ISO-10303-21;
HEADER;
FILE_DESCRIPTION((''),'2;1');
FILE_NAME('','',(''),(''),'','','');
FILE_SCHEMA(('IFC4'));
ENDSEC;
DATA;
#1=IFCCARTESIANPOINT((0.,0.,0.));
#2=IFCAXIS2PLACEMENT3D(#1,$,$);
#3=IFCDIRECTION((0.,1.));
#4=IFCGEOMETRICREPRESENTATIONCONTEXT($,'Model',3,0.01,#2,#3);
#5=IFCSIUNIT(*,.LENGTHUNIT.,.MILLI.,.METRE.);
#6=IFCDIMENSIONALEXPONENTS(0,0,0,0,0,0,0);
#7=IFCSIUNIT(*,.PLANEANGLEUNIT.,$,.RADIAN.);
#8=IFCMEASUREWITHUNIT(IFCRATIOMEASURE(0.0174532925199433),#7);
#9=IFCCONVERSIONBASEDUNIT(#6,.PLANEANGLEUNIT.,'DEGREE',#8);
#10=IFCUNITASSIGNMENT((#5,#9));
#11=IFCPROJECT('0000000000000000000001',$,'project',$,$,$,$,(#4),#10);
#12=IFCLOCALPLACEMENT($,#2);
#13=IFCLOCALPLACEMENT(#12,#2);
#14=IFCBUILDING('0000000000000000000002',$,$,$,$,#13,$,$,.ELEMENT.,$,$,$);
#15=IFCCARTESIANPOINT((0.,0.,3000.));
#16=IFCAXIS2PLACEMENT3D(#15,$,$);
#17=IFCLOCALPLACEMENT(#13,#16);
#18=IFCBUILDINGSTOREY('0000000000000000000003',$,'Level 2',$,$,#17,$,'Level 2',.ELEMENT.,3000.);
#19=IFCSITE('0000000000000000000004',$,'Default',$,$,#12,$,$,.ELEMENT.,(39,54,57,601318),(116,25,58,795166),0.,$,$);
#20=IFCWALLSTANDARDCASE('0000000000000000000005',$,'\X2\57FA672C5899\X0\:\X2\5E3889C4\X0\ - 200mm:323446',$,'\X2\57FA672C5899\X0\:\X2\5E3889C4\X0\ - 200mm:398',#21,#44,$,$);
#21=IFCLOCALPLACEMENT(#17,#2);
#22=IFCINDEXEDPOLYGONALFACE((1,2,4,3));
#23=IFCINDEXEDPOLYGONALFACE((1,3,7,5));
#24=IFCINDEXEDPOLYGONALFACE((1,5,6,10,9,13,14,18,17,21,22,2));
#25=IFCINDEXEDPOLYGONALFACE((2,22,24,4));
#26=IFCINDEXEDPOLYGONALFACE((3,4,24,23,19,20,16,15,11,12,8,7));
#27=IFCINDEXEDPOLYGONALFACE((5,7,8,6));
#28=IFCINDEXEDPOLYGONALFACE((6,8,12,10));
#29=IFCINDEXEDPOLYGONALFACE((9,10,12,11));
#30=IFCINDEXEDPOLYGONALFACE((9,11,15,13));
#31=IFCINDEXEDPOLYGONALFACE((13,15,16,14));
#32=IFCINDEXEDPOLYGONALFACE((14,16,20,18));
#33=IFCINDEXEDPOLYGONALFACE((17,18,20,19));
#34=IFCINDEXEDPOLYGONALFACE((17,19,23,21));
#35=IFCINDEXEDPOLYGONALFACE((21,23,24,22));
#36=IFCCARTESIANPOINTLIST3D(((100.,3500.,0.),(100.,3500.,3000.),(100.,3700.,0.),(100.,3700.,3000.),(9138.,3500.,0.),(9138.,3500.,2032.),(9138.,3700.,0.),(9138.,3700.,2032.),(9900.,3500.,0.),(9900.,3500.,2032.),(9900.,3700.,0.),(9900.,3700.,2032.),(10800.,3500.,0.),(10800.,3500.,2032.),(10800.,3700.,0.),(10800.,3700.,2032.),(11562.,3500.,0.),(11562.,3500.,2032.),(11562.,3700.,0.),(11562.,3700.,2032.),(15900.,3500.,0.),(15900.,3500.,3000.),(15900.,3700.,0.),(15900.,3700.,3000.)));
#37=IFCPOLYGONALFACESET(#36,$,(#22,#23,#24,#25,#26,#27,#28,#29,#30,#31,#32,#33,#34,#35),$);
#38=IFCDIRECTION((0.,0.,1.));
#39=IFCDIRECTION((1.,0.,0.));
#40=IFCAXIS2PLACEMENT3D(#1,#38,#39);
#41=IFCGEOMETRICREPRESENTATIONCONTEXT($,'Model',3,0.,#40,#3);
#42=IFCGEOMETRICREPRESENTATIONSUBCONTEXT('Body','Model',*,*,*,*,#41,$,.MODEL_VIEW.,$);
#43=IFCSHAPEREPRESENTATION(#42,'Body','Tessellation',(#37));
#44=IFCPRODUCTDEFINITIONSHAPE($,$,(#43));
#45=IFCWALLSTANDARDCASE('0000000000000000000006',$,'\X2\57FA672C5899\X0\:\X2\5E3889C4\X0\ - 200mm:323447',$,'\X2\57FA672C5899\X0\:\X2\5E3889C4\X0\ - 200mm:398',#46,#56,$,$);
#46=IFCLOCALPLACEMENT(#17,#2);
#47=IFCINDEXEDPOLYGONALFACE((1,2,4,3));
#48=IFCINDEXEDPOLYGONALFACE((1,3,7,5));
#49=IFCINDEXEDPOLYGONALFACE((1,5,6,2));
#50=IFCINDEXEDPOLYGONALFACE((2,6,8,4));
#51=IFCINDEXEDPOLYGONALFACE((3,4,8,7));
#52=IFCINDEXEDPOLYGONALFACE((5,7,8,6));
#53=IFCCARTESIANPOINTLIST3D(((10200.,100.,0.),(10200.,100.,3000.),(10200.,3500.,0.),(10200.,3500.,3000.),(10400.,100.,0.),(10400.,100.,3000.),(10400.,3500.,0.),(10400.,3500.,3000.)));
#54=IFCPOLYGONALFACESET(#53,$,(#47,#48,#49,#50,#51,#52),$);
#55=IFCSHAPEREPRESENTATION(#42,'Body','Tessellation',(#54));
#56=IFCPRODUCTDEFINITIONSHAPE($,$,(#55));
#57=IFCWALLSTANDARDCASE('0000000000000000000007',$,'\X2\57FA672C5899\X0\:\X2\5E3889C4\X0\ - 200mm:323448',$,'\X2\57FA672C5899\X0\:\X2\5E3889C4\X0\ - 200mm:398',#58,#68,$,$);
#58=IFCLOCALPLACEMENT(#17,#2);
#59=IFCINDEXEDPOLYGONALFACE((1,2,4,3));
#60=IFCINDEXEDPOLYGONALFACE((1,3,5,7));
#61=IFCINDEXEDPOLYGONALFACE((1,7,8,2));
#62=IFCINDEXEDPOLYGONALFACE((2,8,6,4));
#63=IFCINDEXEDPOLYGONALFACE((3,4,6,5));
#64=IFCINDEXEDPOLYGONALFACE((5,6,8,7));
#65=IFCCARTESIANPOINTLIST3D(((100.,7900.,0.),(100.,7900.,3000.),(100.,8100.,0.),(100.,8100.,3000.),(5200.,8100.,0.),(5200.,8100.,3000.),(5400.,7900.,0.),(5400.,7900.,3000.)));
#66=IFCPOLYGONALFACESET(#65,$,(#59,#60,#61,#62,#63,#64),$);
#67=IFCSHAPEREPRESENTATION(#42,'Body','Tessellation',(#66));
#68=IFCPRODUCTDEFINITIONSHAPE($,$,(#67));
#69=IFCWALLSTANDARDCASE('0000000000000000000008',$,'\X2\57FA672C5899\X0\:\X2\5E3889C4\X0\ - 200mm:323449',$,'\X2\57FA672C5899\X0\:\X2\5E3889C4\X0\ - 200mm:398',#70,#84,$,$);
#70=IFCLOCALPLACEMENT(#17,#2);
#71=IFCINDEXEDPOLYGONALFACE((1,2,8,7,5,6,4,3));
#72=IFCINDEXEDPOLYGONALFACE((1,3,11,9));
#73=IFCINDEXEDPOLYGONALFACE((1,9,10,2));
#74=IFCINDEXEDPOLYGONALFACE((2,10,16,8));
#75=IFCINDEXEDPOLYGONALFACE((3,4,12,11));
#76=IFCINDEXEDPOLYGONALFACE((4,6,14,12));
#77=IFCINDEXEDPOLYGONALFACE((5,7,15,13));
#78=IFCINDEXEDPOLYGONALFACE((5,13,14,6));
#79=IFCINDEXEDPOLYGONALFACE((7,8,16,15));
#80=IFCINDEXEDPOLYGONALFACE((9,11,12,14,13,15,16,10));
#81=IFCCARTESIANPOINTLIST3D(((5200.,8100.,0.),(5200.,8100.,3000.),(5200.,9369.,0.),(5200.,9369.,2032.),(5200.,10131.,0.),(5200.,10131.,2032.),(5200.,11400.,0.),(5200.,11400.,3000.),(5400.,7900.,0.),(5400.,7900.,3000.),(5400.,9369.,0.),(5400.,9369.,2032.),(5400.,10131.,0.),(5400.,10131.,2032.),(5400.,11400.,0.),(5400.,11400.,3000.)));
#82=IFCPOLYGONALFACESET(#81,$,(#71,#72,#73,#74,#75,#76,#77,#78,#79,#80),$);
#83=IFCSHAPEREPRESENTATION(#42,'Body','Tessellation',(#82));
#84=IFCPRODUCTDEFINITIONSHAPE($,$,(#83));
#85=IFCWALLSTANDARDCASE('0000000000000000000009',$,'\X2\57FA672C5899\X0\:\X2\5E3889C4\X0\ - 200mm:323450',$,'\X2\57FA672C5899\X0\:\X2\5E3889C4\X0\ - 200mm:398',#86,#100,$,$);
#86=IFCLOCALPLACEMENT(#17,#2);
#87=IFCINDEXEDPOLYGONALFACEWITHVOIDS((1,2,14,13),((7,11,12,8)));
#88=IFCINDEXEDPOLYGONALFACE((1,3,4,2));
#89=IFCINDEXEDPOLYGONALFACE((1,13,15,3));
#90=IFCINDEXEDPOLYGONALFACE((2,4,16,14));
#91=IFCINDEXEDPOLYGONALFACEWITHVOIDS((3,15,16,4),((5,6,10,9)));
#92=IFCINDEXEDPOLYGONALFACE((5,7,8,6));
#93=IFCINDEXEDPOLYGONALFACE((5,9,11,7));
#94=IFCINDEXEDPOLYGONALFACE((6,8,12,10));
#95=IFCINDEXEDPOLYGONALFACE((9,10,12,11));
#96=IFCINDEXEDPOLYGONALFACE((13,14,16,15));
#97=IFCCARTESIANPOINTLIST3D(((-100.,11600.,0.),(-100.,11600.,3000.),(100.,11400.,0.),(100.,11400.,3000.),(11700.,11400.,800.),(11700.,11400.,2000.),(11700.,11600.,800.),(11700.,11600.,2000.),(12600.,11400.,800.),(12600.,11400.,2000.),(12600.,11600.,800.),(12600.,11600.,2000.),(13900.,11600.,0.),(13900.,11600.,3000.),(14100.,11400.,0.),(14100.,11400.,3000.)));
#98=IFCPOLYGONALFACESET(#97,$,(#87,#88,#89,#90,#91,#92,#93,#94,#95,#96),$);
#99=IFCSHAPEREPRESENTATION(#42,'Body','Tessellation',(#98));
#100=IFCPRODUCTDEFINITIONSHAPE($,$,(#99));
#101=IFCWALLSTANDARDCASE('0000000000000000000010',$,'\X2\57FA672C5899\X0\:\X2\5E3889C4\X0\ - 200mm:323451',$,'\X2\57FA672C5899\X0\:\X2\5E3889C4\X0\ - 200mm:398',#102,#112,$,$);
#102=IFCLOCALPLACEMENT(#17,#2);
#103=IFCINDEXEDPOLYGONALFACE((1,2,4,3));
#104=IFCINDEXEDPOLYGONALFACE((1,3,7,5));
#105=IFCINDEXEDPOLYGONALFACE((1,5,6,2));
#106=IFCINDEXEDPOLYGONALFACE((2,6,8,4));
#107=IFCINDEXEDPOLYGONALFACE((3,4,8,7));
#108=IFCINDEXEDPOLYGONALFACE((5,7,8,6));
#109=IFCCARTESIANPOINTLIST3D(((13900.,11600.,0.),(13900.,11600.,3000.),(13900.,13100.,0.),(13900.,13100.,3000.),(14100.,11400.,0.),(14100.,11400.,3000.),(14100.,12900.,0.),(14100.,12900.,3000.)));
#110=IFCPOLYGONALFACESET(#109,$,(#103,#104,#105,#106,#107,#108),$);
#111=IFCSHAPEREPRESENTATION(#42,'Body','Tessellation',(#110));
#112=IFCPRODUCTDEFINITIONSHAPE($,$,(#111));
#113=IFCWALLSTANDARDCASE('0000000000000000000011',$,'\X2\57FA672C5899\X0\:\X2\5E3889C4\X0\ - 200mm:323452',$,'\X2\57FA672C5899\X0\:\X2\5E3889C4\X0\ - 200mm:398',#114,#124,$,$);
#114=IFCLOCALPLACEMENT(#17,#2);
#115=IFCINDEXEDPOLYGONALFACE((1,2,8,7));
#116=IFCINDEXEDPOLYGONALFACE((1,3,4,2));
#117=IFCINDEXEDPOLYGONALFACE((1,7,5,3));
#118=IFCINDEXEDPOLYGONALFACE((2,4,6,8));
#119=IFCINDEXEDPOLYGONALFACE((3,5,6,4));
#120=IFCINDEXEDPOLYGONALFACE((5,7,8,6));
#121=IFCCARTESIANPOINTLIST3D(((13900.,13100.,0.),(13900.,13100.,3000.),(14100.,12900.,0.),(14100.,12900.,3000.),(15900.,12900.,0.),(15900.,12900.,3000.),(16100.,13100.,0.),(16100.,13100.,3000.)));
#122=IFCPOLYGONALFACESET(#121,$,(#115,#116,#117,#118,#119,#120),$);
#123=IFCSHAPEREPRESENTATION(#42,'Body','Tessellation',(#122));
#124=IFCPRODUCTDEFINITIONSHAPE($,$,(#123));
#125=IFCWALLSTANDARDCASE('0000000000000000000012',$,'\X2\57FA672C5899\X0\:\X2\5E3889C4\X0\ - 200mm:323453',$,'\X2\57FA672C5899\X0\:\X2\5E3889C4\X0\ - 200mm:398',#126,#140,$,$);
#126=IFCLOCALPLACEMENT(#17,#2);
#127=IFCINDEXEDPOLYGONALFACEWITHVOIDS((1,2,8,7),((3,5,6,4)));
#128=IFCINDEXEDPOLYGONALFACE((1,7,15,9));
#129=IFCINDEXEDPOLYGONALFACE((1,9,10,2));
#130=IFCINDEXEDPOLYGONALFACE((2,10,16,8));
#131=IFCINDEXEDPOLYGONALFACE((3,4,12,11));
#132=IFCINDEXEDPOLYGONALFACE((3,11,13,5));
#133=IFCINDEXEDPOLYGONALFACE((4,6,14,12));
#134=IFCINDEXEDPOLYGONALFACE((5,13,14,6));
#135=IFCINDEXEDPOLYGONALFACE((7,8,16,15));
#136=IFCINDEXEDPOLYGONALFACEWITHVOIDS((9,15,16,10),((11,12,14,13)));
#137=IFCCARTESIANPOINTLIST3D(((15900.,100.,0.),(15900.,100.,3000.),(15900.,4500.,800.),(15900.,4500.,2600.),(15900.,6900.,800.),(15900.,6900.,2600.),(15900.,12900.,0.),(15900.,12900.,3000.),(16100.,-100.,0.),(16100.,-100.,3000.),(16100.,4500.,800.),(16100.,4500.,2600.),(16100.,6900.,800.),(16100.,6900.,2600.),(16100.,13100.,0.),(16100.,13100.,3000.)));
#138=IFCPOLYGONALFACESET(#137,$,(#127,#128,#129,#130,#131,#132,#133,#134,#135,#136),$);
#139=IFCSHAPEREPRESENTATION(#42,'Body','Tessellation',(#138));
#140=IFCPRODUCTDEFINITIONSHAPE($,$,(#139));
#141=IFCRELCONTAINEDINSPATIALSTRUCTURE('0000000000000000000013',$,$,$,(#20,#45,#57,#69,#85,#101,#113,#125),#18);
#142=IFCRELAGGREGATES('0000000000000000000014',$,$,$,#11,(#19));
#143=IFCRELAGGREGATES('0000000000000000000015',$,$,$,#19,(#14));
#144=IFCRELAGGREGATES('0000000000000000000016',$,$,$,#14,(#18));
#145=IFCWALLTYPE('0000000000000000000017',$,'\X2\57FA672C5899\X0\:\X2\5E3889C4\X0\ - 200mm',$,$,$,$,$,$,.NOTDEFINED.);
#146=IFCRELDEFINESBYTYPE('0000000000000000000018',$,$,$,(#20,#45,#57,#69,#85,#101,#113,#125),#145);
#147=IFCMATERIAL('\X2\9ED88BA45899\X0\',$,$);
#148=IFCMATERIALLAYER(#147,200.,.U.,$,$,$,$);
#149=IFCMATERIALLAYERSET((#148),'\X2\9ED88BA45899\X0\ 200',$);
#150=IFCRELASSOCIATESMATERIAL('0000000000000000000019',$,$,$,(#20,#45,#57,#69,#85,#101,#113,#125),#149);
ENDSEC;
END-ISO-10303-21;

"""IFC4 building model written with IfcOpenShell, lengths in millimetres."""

from ifc_helpers import new_model, entity, si_unit, converted_unit, direction, frame, origin, origin_with_axes, place, context, subcontext, project, spatial, polyline, outline, extrude, material, layer, layer_set, layer_usage, type_object, element, save


model = new_model("IFC4")

# Units and contexts
model_context_1 = context("Model", 3, precision=0.01, world=origin(), true_north=direction((0.0, 1.0)))
model_context_2 = context("Model", 3, precision=0.0, world=origin_with_axes(), true_north=direction((0.0, 1.0)))
body_context_1 = subcontext(model_context_2, "Body", "Model", "MODEL_VIEW")
ifc_project = project(units=[si_unit("LENGTHUNIT", "METRE", prefix="MILLI"), converted_unit("PLANEANGLEUNIT", "DEGREE", entity("IfcRatioMeasure", 0.0174532925199433), si_unit("PLANEANGLEUNIT", "RADIAN"), dimensions=[0, 0, 0, 0, 0, 0, 0])], contexts=[model_context_1])

# Site, building, storey
site_placement = place(None, origin())
site = spatial("IfcSite", under=ifc_project, at=site_placement, Name="Default", CompositionType="ELEMENT", RefLatitude=(39, 54, 57, 601318), RefLongitude=(116, 25, 58, 795166), RefElevation=0.0)
building_placement = place(site_placement, origin())
building = spatial("IfcBuilding", under=site, at=building_placement, CompositionType="ELEMENT")
storey_placement = place(building_placement, frame((0.0, 0.0, 3000.0)))
storey = spatial("IfcBuildingStorey", under=building, at=storey_placement, Name="Level 2", LongName="Level 2", CompositionType="ELEMENT", Elevation=3000.0)

# Shared definitions
placement_1 = place(None, origin_with_axes())
placement_2 = place(placement_1, origin_with_axes())
placement_3 = place(placement_2, frame((0.0, 0.0, 3000.0), z_axis=(0.0, 0.0, 1.0), x_axis=(1.0, 0.0, 0.0)))

# Shared definitions
ifc_material_1 = material(Name="默认墙")
ifc_layer_1 = layer(ifc_material_1, 200.0, ventilated="UNKNOWN")
ifc_layer_set_1 = layer_set([ifc_layer_1], Name="默认墙 200")
wall_type = type_object("IfcWallType", Name="基本墙:常规 - 200mm", PredefinedType="NOTDEFINED")

# Wall, openings
ifc_layer_usage_1 = layer_usage(ifc_layer_set_1, "AXIS2", "POSITIVE", -100.0)
wall_1_placement = place(placement_3, frame((16000.0, 3600.0, 0.0), z_axis=(0.0, 0.0, 1.0), x_axis=(-1.0, 0.0, 0.0)))
wall_1 = element("IfcWallStandardCase", 1, at=wall_1_placement, inside=storey, type_object=wall_type, material=ifc_layer_usage_1, Name="基本墙:常规 - 200mm:323446", ObjectType="基本墙:常规 - 200mm:398", context=body_context_1, shape_type="SweptSolid", body=[
    extrude(outline(polyline([(100.0, -100.0), (15900.0, -100.0), (15900.0, 100.0), (100.0, 100.0), (100.0, -100.0)])), origin_with_axes(), (0.0, 0.0, 1.0), 3000.0),
])
opening_1_placement = place(wall_1_placement, frame((6481.0, 0.0, 0.0), z_axis=(0.0, 0.0, 1.0), x_axis=(1.0, 0.0, 0.0)))
element("IfcOpeningElement", 2, at=opening_1_placement, cuts=wall_1, context=body_context_1, shape_type="SweptSolid", body=[
    extrude(outline(polyline([(-381.0, 0.0), (-381.0, -2032.0), (381.0, -2032.0), (381.0, 0.0), (-381.0, 0.0)])), frame((0.0, 100.0, 0.0), z_axis=(0.0, 1.0, 0.0), x_axis=(1.0, 0.0, 0.0)), (0.0, 0.0, -1.0), 200.0),
])
opening_2_placement = place(wall_1_placement, frame((4819.0, 0.0, 0.0), z_axis=(0.0, 0.0, 1.0), x_axis=(1.0, 0.0, 0.0)))
element("IfcOpeningElement", 3, at=opening_2_placement, cuts=wall_1, context=body_context_1, shape_type="SweptSolid", body=[
    extrude(outline(polyline([(-381.0, -2032.0), (381.0, -2032.0), (381.0, 0.0), (-381.0, 0.0), (-381.0, -2032.0)])), frame((0.0, 100.0, 0.0), z_axis=(0.0, -1.0, 0.0), x_axis=(-1.0, 0.0, 0.0)), (0.0, 0.0, 1.0), 200.0),
])

# Walls
ifc_layer_usage_2 = layer_usage(ifc_layer_set_1, "AXIS2", "POSITIVE", -100.0)
wall_2_placement = place(placement_3, frame((10300.0, 3600.0, 0.0), z_axis=(0.0, 0.0, 1.0), x_axis=(0.0, -1.0, 0.0)))
element("IfcWallStandardCase", 4, at=wall_2_placement, inside=storey, type_object=wall_type, material=ifc_layer_usage_2, Name="基本墙:常规 - 200mm:323447", ObjectType="基本墙:常规 - 200mm:398", context=body_context_1, shape_type="SweptSolid", body=[
    extrude(outline(polyline([(100.0, -100.0), (3500.0, -100.0), (3500.0, 100.0), (100.0, 100.0), (100.0, -100.0)])), origin_with_axes(), (0.0, 0.0, 1.0), 3000.0),
])
ifc_layer_usage_3 = layer_usage(ifc_layer_set_1, "AXIS2", "POSITIVE", -100.0)
wall_3_placement = place(placement_3, frame((0.0, 8000.0, 0.0), z_axis=(0.0, 0.0, 1.0), x_axis=(1.0, 0.0, 0.0)))
element("IfcWallStandardCase", 5, at=wall_3_placement, inside=storey, type_object=wall_type, material=ifc_layer_usage_3, Name="基本墙:常规 - 200mm:323448", ObjectType="基本墙:常规 - 200mm:398", context=body_context_1, shape_type="SweptSolid", body=[
    extrude(outline(polyline([(100.0, -100.0), (5400.0, -100.0), (5200.0, 100.0), (100.0, 100.0), (100.0, -100.0)])), origin_with_axes(), (0.0, 0.0, 1.0), 3000.0),
])

# Walls, openings
ifc_layer_usage_4 = layer_usage(ifc_layer_set_1, "AXIS2", "POSITIVE", -100.0)
wall_4_placement = place(placement_3, frame((5300.0, 8000.0, 0.0), z_axis=(0.0, 0.0, 1.0), x_axis=(0.0, 1.0, 0.0)))
wall_4 = element("IfcWallStandardCase", 6, at=wall_4_placement, inside=storey, type_object=wall_type, material=ifc_layer_usage_4, Name="基本墙:常规 - 200mm:323449", ObjectType="基本墙:常规 - 200mm:398", context=body_context_1, shape_type="SweptSolid", body=[
    extrude(outline(polyline([(-100.0, -100.0), (3400.0, -100.0), (3400.0, 100.0), (100.0, 100.0), (-100.0, -100.0)])), origin_with_axes(), (0.0, 0.0, 1.0), 3000.0),
])
opening_3_placement = place(wall_4_placement, frame((1750.0, 0.0, 0.0), z_axis=(0.0, 0.0, 1.0), x_axis=(1.0, 0.0, 0.0)))
element("IfcOpeningElement", 7, at=opening_3_placement, cuts=wall_4, context=body_context_1, shape_type="SweptSolid", body=[
    extrude(outline(polyline([(-381.0, -2032.0), (381.0, -2032.0), (381.0, 0.0), (-381.0, 0.0), (-381.0, -2032.0)])), frame((0.0, 100.0, 0.0), z_axis=(0.0, -1.0, 0.0), x_axis=(-1.0, 0.0, 0.0)), (0.0, 0.0, 1.0), 200.0),
])
ifc_layer_usage_5 = layer_usage(ifc_layer_set_1, "AXIS2", "POSITIVE", -100.0)
wall_5_placement = place(placement_3, frame((0.0, 11500.0, 0.0), z_axis=(0.0, 0.0, 1.0), x_axis=(1.0, 0.0, 0.0)))
wall_5 = element("IfcWallStandardCase", 8, at=wall_5_placement, inside=storey, type_object=wall_type, material=ifc_layer_usage_5, Name="基本墙:常规 - 200mm:323450", ObjectType="基本墙:常规 - 200mm:398", context=body_context_1, shape_type="SweptSolid", body=[
    extrude(outline(polyline([(100.0, -100.0), (14100.0, -100.0), (13900.0, 100.0), (-100.0, 100.0), (100.0, -100.0)])), origin_with_axes(), (0.0, 0.0, 1.0), 3000.0),
])
opening_4_placement = place(wall_5_placement, frame((12150.0, 0.0, 800.0), z_axis=(0.0, 0.0, 1.0), x_axis=(1.0, 0.0, 0.0)))
element("IfcOpeningElement", 9, at=opening_4_placement, cuts=wall_5, context=body_context_1, shape_type="SweptSolid", body=[
    extrude(outline(polyline([(450.0, -1200.0), (450.0, 0.0), (-450.0, 0.0), (-450.0, -1200.0), (450.0, -1200.0)])), frame((0.0, 100.0, 0.0), z_axis=(0.0, -1.0, 0.0), x_axis=(-1.0, 0.0, 0.0)), (0.0, 0.0, 1.0), 200.0),
])

# Walls
ifc_layer_usage_6 = layer_usage(ifc_layer_set_1, "AXIS2", "POSITIVE", -100.0)
wall_6_placement = place(placement_3, frame((14000.0, 11500.0, 0.0), z_axis=(0.0, 0.0, 1.0), x_axis=(0.0, 1.0, 0.0)))
element("IfcWallStandardCase", 10, at=wall_6_placement, inside=storey, type_object=wall_type, material=ifc_layer_usage_6, Name="基本墙:常规 - 200mm:323451", ObjectType="基本墙:常规 - 200mm:398", context=body_context_1, shape_type="SweptSolid", body=[
    extrude(outline(polyline([(-100.0, -100.0), (1400.0, -100.0), (1600.0, 100.0), (100.0, 100.0), (-100.0, -100.0)])), origin_with_axes(), (0.0, 0.0, 1.0), 3000.0),
])
ifc_layer_usage_7 = layer_usage(ifc_layer_set_1, "AXIS2", "POSITIVE", -100.0)
wall_7_placement = place(placement_3, frame((14000.0, 13000.0, 0.0), z_axis=(0.0, 0.0, 1.0), x_axis=(1.0, 0.0, 0.0)))
element("IfcWallStandardCase", 11, at=wall_7_placement, inside=storey, type_object=wall_type, material=ifc_layer_usage_7, Name="基本墙:常规 - 200mm:323452", ObjectType="基本墙:常规 - 200mm:398", context=body_context_1, shape_type="SweptSolid", body=[
    extrude(outline(polyline([(100.0, -100.0), (1900.0, -100.0), (2100.0, 100.0), (-100.0, 100.0), (100.0, -100.0)])), origin_with_axes(), (0.0, 0.0, 1.0), 3000.0),
])

# Wall, opening
ifc_layer_usage_8 = layer_usage(ifc_layer_set_1, "AXIS2", "POSITIVE", -100.0)
wall_8_placement = place(placement_3, frame((16000.0, 13000.0, 0.0), z_axis=(0.0, 0.0, 1.0), x_axis=(0.0, -1.0, 0.0)))
wall_8 = element("IfcWallStandardCase", 12, at=wall_8_placement, inside=storey, type_object=wall_type, material=ifc_layer_usage_8, Name="基本墙:常规 - 200mm:323453", ObjectType="基本墙:常规 - 200mm:398", context=body_context_1, shape_type="SweptSolid", body=[
    extrude(outline(polyline([(100.0, -100.0), (12900.0, -100.0), (13100.0, 100.0), (-100.0, 100.0), (100.0, -100.0)])), origin_with_axes(), (0.0, 0.0, 1.0), 3000.0),
])
opening_5_placement = place(wall_8_placement, frame((7300.0, 0.0, 800.0), z_axis=(0.0, 0.0, 1.0), x_axis=(1.0, 0.0, 0.0)))
element("IfcOpeningElement", 13, at=opening_5_placement, cuts=wall_8, context=body_context_1, shape_type="SweptSolid", body=[
    extrude(outline(polyline([(-1200.0, 0.0), (-1200.0, -1800.0), (1200.0, -1800.0), (1200.0, 0.0), (-1200.0, 0.0)])), frame((0.0, -100.0, 0.0), z_axis=(0.0, 1.0, 0.0), x_axis=(1.0, 0.0, 0.0)), (0.0, 0.0, 1.0), 200.0),
])

save(model, "model.ifc")
